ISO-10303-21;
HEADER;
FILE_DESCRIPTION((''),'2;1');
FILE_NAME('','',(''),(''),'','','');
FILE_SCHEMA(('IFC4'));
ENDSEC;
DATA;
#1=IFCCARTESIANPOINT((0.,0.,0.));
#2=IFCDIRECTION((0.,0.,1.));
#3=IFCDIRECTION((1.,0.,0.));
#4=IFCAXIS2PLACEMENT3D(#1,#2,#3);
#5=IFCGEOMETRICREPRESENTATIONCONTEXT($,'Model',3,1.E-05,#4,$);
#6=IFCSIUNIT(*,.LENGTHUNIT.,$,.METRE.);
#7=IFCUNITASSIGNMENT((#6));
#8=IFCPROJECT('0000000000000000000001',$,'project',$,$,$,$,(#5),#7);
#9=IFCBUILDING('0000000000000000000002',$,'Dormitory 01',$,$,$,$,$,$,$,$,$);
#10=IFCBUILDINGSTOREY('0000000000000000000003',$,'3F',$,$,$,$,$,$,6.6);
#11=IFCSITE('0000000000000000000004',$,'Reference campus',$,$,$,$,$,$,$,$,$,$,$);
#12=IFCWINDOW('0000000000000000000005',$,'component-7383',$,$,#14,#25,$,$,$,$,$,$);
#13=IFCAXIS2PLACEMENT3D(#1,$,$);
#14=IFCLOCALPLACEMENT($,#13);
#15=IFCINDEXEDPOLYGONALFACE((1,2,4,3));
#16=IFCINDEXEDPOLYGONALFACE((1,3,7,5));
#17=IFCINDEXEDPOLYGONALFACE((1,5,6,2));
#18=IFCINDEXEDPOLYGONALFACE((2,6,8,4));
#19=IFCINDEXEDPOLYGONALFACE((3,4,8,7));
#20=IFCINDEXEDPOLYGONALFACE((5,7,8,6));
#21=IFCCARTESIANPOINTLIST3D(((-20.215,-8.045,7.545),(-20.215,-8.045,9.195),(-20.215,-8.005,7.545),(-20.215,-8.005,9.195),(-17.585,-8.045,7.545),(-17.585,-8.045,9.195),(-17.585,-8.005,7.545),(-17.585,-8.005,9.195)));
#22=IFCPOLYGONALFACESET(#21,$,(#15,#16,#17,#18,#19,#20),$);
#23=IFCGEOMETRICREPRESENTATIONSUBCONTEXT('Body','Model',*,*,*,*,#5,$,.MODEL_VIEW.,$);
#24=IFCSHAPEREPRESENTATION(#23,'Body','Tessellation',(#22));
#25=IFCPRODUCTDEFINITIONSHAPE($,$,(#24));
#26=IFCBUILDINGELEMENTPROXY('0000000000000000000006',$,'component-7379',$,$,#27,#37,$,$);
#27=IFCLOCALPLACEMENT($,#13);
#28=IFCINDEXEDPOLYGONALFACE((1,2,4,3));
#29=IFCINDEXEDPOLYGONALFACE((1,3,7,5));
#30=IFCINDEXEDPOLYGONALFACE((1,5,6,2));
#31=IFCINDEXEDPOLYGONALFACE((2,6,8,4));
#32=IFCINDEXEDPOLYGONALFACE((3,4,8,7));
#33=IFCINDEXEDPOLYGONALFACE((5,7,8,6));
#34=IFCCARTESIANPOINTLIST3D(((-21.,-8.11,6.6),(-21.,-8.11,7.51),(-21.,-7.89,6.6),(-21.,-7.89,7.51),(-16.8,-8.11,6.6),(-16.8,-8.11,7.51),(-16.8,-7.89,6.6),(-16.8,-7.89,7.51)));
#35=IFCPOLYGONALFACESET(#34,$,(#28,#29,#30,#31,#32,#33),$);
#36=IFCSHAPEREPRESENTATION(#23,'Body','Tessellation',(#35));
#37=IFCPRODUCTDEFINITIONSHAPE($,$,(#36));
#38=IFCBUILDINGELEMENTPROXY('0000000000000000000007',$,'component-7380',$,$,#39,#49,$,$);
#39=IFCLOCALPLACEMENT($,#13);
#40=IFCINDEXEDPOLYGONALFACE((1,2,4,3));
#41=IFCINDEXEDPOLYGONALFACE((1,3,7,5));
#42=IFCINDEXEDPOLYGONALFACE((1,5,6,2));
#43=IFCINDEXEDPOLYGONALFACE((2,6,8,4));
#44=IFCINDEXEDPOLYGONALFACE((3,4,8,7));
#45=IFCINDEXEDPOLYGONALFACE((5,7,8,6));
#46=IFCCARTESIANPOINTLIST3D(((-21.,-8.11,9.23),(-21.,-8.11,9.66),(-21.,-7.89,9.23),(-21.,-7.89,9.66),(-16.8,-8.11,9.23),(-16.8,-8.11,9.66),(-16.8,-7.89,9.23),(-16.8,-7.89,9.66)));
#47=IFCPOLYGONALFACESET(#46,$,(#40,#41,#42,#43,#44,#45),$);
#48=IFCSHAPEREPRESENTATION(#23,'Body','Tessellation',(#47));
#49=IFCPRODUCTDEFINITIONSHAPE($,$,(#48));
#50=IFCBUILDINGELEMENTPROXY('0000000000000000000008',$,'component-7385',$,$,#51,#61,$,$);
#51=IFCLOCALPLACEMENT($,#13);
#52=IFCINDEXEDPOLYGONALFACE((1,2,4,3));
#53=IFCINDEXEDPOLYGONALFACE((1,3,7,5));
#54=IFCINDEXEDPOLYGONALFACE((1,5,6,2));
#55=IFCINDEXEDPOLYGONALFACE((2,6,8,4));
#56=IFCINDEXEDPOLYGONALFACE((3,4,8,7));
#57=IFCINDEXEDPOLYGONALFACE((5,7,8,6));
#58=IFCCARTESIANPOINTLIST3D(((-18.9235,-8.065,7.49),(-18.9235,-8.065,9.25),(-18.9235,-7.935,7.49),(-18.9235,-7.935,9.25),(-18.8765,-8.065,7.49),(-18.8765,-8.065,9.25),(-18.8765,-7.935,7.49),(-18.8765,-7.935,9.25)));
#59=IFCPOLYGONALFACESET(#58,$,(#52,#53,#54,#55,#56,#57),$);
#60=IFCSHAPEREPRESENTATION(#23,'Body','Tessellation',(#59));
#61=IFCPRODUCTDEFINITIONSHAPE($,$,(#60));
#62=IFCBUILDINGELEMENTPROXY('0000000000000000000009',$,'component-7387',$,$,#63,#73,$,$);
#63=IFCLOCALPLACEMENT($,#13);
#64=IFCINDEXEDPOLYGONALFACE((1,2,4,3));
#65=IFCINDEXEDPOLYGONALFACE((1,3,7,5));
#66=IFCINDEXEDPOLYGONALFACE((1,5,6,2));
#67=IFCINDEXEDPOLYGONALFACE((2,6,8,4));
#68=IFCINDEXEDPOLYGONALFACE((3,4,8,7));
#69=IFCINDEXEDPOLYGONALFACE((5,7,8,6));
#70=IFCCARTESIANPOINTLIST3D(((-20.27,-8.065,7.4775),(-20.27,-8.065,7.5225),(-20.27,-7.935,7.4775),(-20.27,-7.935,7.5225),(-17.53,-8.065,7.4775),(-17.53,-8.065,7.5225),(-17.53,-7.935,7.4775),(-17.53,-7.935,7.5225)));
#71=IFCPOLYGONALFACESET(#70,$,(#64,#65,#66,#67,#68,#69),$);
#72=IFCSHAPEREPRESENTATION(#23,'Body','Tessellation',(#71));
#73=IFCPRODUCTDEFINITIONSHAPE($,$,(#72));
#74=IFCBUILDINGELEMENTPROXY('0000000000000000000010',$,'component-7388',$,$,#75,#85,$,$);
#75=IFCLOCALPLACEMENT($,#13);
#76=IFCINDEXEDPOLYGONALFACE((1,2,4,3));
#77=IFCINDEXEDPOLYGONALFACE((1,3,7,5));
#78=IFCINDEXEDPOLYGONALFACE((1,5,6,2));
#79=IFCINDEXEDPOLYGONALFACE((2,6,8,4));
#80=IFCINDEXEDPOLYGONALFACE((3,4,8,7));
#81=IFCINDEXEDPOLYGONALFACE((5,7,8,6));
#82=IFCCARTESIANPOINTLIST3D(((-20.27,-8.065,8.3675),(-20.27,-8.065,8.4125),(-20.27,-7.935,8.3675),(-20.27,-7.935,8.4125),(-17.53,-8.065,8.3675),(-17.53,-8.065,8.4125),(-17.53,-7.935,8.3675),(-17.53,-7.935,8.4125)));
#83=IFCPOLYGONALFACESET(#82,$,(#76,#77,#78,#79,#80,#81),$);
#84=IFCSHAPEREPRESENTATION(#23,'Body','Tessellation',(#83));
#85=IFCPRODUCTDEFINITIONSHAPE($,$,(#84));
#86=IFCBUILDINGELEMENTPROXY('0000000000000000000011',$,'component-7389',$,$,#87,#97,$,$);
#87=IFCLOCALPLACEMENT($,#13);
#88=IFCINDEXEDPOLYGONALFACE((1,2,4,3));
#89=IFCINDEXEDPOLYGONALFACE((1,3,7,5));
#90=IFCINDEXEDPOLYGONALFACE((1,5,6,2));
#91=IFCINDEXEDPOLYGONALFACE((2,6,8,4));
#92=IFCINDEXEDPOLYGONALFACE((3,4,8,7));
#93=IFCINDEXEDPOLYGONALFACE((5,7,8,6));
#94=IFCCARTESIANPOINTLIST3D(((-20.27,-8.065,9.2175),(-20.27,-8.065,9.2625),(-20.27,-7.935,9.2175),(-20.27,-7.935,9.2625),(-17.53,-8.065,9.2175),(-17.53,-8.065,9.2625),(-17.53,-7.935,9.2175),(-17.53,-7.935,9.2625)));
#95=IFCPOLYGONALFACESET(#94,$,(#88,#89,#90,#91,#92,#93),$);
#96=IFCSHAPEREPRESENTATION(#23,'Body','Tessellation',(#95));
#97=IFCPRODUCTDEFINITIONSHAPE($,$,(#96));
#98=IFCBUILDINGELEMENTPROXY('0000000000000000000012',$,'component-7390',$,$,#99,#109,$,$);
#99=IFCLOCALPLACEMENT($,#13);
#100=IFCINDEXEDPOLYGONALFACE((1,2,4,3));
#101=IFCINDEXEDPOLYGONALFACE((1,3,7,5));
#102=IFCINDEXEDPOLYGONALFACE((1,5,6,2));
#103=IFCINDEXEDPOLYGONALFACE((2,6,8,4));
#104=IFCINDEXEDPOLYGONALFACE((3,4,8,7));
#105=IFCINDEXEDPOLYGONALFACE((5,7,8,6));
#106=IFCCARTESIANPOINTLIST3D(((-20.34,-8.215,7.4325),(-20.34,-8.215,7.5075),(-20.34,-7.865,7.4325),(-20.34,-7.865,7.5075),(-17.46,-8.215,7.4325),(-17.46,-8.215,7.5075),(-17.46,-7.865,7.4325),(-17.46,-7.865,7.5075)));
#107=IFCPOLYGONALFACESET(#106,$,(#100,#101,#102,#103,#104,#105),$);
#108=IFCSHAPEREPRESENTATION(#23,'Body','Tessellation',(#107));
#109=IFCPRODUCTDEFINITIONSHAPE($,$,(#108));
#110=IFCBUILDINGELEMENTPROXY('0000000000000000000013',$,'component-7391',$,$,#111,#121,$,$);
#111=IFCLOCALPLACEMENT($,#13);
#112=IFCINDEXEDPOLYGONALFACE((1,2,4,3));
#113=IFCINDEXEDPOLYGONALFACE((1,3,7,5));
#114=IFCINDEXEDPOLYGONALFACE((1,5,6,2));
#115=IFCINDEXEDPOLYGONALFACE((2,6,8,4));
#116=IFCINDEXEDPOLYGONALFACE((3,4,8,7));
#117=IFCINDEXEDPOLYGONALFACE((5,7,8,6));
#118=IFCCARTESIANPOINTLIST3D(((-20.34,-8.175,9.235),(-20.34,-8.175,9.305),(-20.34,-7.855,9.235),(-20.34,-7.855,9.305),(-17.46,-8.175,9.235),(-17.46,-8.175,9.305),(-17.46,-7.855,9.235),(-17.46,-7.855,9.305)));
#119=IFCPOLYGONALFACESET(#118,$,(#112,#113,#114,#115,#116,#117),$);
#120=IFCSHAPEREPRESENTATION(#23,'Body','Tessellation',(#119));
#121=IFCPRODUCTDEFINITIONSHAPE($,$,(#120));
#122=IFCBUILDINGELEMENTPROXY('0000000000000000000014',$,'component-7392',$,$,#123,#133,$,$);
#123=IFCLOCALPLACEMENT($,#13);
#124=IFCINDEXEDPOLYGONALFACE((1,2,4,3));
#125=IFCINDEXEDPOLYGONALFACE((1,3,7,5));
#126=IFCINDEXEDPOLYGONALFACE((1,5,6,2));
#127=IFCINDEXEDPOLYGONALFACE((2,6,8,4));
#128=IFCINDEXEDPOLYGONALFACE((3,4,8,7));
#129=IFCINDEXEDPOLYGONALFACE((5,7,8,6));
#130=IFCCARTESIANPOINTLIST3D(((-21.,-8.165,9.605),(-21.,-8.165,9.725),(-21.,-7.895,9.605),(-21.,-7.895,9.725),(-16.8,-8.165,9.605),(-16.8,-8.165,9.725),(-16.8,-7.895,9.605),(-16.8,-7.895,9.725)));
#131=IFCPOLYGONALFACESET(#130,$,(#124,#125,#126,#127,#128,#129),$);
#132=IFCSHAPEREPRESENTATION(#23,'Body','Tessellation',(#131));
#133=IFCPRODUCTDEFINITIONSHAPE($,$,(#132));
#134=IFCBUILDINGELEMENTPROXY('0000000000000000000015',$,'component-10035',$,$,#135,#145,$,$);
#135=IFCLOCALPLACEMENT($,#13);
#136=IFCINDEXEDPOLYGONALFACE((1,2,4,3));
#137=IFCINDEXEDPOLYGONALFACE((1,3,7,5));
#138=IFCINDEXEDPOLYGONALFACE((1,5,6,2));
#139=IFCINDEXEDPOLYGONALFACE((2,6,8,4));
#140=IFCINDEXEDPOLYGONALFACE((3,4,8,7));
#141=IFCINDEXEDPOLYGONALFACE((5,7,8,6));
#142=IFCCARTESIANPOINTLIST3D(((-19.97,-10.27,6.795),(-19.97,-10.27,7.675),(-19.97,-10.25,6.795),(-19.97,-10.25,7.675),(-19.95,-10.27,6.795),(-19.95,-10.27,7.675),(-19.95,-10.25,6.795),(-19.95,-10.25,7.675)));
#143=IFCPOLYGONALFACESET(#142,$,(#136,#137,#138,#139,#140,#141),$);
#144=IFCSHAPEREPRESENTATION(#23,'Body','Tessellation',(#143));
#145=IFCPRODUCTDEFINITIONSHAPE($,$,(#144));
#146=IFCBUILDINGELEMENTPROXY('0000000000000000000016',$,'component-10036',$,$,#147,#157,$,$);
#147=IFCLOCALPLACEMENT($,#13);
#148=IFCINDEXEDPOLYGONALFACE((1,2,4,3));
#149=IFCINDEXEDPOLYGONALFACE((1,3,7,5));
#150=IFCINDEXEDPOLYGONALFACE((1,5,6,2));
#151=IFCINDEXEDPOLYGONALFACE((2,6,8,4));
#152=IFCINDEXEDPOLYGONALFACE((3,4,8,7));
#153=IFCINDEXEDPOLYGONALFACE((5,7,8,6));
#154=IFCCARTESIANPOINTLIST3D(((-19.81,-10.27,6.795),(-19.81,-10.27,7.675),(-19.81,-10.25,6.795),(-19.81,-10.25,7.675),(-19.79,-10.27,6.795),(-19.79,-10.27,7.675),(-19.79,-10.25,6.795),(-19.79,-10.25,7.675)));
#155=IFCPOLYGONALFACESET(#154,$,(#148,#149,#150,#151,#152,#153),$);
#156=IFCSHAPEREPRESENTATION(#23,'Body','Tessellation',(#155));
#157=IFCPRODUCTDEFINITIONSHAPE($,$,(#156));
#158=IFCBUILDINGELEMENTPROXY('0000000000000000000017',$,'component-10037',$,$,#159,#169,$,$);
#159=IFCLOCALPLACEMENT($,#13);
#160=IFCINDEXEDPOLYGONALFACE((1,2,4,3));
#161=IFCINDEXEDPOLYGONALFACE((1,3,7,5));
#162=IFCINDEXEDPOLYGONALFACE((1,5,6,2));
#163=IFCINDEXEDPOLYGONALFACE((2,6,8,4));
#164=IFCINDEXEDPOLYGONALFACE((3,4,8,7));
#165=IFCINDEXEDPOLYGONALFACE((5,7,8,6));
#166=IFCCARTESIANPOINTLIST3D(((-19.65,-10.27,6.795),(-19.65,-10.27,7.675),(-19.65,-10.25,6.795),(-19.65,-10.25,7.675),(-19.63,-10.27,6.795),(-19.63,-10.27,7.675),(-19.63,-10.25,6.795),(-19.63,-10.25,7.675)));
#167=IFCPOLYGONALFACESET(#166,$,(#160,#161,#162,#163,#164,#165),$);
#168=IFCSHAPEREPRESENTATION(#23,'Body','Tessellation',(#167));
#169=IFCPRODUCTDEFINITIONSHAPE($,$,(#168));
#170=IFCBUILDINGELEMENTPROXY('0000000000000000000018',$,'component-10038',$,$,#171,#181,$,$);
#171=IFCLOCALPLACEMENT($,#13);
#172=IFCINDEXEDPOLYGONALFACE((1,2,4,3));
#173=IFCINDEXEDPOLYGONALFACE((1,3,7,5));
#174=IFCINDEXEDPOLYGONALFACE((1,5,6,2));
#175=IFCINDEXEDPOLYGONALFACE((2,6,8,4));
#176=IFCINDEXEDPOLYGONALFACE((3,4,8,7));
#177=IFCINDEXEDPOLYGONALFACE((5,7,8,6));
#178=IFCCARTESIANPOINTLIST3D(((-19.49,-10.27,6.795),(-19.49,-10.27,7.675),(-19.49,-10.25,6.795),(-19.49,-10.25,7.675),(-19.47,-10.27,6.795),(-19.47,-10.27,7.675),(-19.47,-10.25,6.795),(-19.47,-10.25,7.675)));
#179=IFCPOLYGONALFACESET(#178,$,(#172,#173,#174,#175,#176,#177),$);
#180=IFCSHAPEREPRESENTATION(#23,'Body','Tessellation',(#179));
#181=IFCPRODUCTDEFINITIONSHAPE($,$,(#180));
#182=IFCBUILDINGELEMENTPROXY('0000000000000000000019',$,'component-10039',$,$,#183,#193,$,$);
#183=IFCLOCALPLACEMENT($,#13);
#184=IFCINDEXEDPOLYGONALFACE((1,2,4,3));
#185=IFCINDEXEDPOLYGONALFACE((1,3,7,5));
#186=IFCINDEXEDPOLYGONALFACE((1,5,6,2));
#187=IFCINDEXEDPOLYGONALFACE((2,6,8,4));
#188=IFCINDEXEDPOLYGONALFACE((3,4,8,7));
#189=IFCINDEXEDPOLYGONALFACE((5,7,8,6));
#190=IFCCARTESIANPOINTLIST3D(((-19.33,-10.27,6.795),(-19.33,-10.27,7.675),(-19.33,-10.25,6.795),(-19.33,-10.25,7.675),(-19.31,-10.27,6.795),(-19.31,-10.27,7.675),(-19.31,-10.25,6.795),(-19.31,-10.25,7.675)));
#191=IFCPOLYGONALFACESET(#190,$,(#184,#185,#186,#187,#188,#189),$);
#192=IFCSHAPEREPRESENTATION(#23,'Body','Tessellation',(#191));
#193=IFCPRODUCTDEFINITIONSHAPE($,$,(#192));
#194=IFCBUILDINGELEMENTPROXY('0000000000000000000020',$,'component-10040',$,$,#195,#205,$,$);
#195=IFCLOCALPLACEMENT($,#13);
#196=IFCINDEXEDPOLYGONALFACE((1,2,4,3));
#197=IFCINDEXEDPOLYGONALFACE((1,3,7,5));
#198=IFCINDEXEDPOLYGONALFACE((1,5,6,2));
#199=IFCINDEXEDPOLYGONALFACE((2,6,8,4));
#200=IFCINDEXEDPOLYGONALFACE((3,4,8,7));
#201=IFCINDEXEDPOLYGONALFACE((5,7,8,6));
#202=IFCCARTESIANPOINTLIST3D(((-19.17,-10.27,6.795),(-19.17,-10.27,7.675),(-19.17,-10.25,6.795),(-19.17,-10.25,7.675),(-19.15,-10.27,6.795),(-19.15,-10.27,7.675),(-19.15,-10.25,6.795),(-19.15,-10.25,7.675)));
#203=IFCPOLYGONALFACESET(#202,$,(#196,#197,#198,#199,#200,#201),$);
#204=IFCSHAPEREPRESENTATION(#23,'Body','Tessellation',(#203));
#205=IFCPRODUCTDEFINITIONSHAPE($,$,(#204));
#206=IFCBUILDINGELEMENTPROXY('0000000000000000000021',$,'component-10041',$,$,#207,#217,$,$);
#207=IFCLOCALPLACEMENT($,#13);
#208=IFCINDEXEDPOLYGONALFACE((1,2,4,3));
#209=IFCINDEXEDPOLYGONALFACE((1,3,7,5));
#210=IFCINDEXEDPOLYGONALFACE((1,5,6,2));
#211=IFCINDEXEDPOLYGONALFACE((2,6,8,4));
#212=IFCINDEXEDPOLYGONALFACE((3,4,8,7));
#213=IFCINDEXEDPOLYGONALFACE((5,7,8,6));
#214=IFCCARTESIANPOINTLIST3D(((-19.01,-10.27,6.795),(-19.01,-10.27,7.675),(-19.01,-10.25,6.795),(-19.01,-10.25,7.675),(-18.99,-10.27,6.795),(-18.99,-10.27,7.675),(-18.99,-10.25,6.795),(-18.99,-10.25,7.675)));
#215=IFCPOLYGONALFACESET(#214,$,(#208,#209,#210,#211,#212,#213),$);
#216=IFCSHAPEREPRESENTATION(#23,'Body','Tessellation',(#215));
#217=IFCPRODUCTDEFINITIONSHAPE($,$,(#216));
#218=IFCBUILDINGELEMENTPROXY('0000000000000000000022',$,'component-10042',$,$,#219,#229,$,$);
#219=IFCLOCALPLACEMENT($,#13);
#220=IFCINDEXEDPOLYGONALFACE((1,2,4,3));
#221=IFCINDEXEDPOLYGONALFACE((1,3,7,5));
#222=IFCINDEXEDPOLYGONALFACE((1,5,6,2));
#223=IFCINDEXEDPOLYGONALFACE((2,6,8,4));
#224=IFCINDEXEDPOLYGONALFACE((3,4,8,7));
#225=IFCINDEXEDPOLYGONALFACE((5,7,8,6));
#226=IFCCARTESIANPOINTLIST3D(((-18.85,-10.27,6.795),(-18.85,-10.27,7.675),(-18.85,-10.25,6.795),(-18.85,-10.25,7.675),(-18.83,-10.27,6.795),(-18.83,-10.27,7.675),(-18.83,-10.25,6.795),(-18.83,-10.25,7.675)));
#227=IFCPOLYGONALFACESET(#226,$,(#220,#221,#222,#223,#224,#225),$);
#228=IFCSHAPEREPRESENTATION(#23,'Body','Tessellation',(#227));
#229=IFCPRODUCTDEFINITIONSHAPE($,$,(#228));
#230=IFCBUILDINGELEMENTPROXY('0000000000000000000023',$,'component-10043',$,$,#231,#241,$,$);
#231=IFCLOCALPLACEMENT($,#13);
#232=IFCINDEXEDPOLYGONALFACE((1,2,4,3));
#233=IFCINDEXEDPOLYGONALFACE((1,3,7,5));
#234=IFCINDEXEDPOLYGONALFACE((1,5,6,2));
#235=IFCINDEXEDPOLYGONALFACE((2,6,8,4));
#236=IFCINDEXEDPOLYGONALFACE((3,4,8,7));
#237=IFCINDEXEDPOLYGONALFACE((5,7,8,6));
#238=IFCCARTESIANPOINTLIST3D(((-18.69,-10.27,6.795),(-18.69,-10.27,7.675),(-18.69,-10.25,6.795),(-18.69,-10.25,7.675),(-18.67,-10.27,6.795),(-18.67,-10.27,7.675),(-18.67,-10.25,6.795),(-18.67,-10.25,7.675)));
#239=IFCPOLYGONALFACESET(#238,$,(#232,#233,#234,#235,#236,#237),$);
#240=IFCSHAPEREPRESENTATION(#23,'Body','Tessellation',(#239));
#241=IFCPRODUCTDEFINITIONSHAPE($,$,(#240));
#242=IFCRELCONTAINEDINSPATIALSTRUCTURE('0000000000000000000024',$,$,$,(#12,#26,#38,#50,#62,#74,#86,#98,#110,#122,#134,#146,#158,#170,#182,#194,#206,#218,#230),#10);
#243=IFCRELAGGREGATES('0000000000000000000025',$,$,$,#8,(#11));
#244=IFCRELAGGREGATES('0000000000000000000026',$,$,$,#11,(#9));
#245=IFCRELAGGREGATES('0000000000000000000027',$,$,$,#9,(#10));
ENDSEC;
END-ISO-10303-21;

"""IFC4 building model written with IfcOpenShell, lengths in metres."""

from ifc_helpers import new_model, si_unit, frame, origin, origin_with_axes, origin_2d, place, context, subcontext, project, spatial, rectangle, extrude, element, save


model = new_model("IFC4")

# Units and contexts
model_context = context("Model", 3, precision=1e-05, world=origin_with_axes())
body_context = subcontext(model_context, "Body", "Model", "MODEL_VIEW")
ifc_project = project(units=[si_unit("LENGTHUNIT", "METRE")], contexts=[model_context])

# Site, building, storey
site = spatial("IfcSite", under=ifc_project, Name="Reference campus")
building = spatial("IfcBuilding", under=site, Name="Dormitory 01")
storey = spatial("IfcBuildingStorey", under=building, Name="3F", Elevation=6.6)

# Window
window_placement = place(None, frame((-18.9, -8.025, 7.545), z_axis=(0.0, 0.0, 1.0), x_axis=(1.0, 0.0, 0.0)))
element("IfcWindow", 1, at=window_placement, inside=storey, Name="component-7383", context=body_context, shape_type="SweptSolid", body=[
    extrude(rectangle(XDim=2.63, YDim=0.04, at=origin_2d()), origin(), (0.0, 0.0, 1.0), 1.65),
])

# Building element proxies
proxy_1_placement = place(None, frame((-18.9, -8.0, 6.6), z_axis=(0.0, 0.0, 1.0), x_axis=(1.0, 0.0, 0.0)))
element("IfcBuildingElementProxy", 2, at=proxy_1_placement, inside=storey, Name="component-7379", context=body_context, shape_type="SweptSolid", body=[
    extrude(rectangle(XDim=4.2, YDim=0.22, at=origin_2d()), origin(), (0.0, 0.0, 1.0), 0.91),
])
proxy_2_placement = place(None, frame((-18.9, -8.0, 9.23), z_axis=(0.0, 0.0, 1.0), x_axis=(1.0, 0.0, 0.0)))
element("IfcBuildingElementProxy", 3, at=proxy_2_placement, inside=storey, Name="component-7380", context=body_context, shape_type="SweptSolid", body=[
    extrude(rectangle(XDim=4.2, YDim=0.22, at=origin_2d()), origin(), (0.0, 0.0, 1.0), 0.43),
])
proxy_3_placement = place(None, frame((-18.9, -8.0, 7.49), z_axis=(0.0, 0.0, 1.0), x_axis=(1.0, 0.0, 0.0)))
element("IfcBuildingElementProxy", 4, at=proxy_3_placement, inside=storey, Name="component-7385", context=body_context, shape_type="SweptSolid", body=[
    extrude(rectangle(XDim=0.047, YDim=0.13, at=origin_2d()), origin(), (0.0, 0.0, 1.0), 1.76),
])
for number, where, z_axis, x_axis, name in (
    (5, (-18.9, -8.0, 7.4775), (0.0, 0.0, 1.0), (1.0, 0.0, 0.0), "component-7387"),
    (6, (-18.9, -8.0, 8.3675), (0.0, 0.0, 1.0), (1.0, 0.0, 0.0), "component-7388"),
    (7, (-18.9, -8.0, 9.2175), (0.0, 0.0, 1.0), (1.0, 0.0, 0.0), "component-7389"),
):
    element("IfcBuildingElementProxy", number, at=place(None, frame(where, z_axis=z_axis, x_axis=x_axis)), inside=storey, Name=name, context=body_context, shape_type="SweptSolid", body=[
        extrude(rectangle(XDim=2.74, YDim=0.13, at=origin_2d()), origin(), (0.0, 0.0, 1.0), 0.045),
    ])
proxy_4_placement = place(None, frame((-18.9, -8.04, 7.4325), z_axis=(0.0, 0.0, 1.0), x_axis=(1.0, 0.0, 0.0)))
element("IfcBuildingElementProxy", 8, at=proxy_4_placement, inside=storey, Name="component-7390", context=body_context, shape_type="SweptSolid", body=[
    extrude(rectangle(XDim=2.88, YDim=0.35, at=origin_2d()), origin(), (0.0, 0.0, 1.0), 0.075),
])
proxy_5_placement = place(None, frame((-18.9, -8.015, 9.235), z_axis=(0.0, 0.0, 1.0), x_axis=(1.0, 0.0, 0.0)))
element("IfcBuildingElementProxy", 9, at=proxy_5_placement, inside=storey, Name="component-7391", context=body_context, shape_type="SweptSolid", body=[
    extrude(rectangle(XDim=2.88, YDim=0.32, at=origin_2d()), origin(), (0.0, 0.0, 1.0), 0.07),
])
proxy_6_placement = place(None, frame((-18.9, -8.03, 9.605), z_axis=(0.0, 0.0, 1.0), x_axis=(1.0, 0.0, 0.0)))
element("IfcBuildingElementProxy", 10, at=proxy_6_placement, inside=storey, Name="component-7392", context=body_context, shape_type="SweptSolid", body=[
    extrude(rectangle(XDim=4.2, YDim=0.27, at=origin_2d()), origin(), (0.0, 0.0, 1.0), 0.12),
])
for number, where, z_axis, x_axis, name in (
    (11, (-19.96, -10.26, 6.795), (0.0, 0.0, 1.0), (1.0, 0.0, 0.0), "component-10035"),
    (12, (-19.8, -10.26, 6.795), (0.0, 0.0, 1.0), (1.0, 0.0, 0.0), "component-10036"),
    (13, (-19.64, -10.26, 6.795), (0.0, 0.0, 1.0), (1.0, 0.0, 0.0), "component-10037"),
    (14, (-19.48, -10.26, 6.795), (0.0, 0.0, 1.0), (1.0, 0.0, 0.0), "component-10038"),
    (15, (-19.32, -10.26, 6.795), (0.0, 0.0, 1.0), (1.0, 0.0, 0.0), "component-10039"),
    (16, (-19.16, -10.26, 6.795), (0.0, 0.0, 1.0), (1.0, 0.0, 0.0), "component-10040"),
    (17, (-19.0, -10.26, 6.795), (0.0, 0.0, 1.0), (1.0, 0.0, 0.0), "component-10041"),
    (18, (-18.84, -10.26, 6.795), (0.0, 0.0, 1.0), (1.0, 0.0, 0.0), "component-10042"),
    (19, (-18.68, -10.26, 6.795), (0.0, 0.0, 1.0), (1.0, 0.0, 0.0), "component-10043"),
):
    element("IfcBuildingElementProxy", number, at=place(None, frame(where, z_axis=z_axis, x_axis=x_axis)), inside=storey, Name=name, context=body_context, shape_type="SweptSolid", body=[
        extrude(rectangle(XDim=0.02, YDim=0.02, at=origin_2d()), origin(), (0.0, 0.0, 1.0), 0.88),
    ])

save(model, "model.ifc")
